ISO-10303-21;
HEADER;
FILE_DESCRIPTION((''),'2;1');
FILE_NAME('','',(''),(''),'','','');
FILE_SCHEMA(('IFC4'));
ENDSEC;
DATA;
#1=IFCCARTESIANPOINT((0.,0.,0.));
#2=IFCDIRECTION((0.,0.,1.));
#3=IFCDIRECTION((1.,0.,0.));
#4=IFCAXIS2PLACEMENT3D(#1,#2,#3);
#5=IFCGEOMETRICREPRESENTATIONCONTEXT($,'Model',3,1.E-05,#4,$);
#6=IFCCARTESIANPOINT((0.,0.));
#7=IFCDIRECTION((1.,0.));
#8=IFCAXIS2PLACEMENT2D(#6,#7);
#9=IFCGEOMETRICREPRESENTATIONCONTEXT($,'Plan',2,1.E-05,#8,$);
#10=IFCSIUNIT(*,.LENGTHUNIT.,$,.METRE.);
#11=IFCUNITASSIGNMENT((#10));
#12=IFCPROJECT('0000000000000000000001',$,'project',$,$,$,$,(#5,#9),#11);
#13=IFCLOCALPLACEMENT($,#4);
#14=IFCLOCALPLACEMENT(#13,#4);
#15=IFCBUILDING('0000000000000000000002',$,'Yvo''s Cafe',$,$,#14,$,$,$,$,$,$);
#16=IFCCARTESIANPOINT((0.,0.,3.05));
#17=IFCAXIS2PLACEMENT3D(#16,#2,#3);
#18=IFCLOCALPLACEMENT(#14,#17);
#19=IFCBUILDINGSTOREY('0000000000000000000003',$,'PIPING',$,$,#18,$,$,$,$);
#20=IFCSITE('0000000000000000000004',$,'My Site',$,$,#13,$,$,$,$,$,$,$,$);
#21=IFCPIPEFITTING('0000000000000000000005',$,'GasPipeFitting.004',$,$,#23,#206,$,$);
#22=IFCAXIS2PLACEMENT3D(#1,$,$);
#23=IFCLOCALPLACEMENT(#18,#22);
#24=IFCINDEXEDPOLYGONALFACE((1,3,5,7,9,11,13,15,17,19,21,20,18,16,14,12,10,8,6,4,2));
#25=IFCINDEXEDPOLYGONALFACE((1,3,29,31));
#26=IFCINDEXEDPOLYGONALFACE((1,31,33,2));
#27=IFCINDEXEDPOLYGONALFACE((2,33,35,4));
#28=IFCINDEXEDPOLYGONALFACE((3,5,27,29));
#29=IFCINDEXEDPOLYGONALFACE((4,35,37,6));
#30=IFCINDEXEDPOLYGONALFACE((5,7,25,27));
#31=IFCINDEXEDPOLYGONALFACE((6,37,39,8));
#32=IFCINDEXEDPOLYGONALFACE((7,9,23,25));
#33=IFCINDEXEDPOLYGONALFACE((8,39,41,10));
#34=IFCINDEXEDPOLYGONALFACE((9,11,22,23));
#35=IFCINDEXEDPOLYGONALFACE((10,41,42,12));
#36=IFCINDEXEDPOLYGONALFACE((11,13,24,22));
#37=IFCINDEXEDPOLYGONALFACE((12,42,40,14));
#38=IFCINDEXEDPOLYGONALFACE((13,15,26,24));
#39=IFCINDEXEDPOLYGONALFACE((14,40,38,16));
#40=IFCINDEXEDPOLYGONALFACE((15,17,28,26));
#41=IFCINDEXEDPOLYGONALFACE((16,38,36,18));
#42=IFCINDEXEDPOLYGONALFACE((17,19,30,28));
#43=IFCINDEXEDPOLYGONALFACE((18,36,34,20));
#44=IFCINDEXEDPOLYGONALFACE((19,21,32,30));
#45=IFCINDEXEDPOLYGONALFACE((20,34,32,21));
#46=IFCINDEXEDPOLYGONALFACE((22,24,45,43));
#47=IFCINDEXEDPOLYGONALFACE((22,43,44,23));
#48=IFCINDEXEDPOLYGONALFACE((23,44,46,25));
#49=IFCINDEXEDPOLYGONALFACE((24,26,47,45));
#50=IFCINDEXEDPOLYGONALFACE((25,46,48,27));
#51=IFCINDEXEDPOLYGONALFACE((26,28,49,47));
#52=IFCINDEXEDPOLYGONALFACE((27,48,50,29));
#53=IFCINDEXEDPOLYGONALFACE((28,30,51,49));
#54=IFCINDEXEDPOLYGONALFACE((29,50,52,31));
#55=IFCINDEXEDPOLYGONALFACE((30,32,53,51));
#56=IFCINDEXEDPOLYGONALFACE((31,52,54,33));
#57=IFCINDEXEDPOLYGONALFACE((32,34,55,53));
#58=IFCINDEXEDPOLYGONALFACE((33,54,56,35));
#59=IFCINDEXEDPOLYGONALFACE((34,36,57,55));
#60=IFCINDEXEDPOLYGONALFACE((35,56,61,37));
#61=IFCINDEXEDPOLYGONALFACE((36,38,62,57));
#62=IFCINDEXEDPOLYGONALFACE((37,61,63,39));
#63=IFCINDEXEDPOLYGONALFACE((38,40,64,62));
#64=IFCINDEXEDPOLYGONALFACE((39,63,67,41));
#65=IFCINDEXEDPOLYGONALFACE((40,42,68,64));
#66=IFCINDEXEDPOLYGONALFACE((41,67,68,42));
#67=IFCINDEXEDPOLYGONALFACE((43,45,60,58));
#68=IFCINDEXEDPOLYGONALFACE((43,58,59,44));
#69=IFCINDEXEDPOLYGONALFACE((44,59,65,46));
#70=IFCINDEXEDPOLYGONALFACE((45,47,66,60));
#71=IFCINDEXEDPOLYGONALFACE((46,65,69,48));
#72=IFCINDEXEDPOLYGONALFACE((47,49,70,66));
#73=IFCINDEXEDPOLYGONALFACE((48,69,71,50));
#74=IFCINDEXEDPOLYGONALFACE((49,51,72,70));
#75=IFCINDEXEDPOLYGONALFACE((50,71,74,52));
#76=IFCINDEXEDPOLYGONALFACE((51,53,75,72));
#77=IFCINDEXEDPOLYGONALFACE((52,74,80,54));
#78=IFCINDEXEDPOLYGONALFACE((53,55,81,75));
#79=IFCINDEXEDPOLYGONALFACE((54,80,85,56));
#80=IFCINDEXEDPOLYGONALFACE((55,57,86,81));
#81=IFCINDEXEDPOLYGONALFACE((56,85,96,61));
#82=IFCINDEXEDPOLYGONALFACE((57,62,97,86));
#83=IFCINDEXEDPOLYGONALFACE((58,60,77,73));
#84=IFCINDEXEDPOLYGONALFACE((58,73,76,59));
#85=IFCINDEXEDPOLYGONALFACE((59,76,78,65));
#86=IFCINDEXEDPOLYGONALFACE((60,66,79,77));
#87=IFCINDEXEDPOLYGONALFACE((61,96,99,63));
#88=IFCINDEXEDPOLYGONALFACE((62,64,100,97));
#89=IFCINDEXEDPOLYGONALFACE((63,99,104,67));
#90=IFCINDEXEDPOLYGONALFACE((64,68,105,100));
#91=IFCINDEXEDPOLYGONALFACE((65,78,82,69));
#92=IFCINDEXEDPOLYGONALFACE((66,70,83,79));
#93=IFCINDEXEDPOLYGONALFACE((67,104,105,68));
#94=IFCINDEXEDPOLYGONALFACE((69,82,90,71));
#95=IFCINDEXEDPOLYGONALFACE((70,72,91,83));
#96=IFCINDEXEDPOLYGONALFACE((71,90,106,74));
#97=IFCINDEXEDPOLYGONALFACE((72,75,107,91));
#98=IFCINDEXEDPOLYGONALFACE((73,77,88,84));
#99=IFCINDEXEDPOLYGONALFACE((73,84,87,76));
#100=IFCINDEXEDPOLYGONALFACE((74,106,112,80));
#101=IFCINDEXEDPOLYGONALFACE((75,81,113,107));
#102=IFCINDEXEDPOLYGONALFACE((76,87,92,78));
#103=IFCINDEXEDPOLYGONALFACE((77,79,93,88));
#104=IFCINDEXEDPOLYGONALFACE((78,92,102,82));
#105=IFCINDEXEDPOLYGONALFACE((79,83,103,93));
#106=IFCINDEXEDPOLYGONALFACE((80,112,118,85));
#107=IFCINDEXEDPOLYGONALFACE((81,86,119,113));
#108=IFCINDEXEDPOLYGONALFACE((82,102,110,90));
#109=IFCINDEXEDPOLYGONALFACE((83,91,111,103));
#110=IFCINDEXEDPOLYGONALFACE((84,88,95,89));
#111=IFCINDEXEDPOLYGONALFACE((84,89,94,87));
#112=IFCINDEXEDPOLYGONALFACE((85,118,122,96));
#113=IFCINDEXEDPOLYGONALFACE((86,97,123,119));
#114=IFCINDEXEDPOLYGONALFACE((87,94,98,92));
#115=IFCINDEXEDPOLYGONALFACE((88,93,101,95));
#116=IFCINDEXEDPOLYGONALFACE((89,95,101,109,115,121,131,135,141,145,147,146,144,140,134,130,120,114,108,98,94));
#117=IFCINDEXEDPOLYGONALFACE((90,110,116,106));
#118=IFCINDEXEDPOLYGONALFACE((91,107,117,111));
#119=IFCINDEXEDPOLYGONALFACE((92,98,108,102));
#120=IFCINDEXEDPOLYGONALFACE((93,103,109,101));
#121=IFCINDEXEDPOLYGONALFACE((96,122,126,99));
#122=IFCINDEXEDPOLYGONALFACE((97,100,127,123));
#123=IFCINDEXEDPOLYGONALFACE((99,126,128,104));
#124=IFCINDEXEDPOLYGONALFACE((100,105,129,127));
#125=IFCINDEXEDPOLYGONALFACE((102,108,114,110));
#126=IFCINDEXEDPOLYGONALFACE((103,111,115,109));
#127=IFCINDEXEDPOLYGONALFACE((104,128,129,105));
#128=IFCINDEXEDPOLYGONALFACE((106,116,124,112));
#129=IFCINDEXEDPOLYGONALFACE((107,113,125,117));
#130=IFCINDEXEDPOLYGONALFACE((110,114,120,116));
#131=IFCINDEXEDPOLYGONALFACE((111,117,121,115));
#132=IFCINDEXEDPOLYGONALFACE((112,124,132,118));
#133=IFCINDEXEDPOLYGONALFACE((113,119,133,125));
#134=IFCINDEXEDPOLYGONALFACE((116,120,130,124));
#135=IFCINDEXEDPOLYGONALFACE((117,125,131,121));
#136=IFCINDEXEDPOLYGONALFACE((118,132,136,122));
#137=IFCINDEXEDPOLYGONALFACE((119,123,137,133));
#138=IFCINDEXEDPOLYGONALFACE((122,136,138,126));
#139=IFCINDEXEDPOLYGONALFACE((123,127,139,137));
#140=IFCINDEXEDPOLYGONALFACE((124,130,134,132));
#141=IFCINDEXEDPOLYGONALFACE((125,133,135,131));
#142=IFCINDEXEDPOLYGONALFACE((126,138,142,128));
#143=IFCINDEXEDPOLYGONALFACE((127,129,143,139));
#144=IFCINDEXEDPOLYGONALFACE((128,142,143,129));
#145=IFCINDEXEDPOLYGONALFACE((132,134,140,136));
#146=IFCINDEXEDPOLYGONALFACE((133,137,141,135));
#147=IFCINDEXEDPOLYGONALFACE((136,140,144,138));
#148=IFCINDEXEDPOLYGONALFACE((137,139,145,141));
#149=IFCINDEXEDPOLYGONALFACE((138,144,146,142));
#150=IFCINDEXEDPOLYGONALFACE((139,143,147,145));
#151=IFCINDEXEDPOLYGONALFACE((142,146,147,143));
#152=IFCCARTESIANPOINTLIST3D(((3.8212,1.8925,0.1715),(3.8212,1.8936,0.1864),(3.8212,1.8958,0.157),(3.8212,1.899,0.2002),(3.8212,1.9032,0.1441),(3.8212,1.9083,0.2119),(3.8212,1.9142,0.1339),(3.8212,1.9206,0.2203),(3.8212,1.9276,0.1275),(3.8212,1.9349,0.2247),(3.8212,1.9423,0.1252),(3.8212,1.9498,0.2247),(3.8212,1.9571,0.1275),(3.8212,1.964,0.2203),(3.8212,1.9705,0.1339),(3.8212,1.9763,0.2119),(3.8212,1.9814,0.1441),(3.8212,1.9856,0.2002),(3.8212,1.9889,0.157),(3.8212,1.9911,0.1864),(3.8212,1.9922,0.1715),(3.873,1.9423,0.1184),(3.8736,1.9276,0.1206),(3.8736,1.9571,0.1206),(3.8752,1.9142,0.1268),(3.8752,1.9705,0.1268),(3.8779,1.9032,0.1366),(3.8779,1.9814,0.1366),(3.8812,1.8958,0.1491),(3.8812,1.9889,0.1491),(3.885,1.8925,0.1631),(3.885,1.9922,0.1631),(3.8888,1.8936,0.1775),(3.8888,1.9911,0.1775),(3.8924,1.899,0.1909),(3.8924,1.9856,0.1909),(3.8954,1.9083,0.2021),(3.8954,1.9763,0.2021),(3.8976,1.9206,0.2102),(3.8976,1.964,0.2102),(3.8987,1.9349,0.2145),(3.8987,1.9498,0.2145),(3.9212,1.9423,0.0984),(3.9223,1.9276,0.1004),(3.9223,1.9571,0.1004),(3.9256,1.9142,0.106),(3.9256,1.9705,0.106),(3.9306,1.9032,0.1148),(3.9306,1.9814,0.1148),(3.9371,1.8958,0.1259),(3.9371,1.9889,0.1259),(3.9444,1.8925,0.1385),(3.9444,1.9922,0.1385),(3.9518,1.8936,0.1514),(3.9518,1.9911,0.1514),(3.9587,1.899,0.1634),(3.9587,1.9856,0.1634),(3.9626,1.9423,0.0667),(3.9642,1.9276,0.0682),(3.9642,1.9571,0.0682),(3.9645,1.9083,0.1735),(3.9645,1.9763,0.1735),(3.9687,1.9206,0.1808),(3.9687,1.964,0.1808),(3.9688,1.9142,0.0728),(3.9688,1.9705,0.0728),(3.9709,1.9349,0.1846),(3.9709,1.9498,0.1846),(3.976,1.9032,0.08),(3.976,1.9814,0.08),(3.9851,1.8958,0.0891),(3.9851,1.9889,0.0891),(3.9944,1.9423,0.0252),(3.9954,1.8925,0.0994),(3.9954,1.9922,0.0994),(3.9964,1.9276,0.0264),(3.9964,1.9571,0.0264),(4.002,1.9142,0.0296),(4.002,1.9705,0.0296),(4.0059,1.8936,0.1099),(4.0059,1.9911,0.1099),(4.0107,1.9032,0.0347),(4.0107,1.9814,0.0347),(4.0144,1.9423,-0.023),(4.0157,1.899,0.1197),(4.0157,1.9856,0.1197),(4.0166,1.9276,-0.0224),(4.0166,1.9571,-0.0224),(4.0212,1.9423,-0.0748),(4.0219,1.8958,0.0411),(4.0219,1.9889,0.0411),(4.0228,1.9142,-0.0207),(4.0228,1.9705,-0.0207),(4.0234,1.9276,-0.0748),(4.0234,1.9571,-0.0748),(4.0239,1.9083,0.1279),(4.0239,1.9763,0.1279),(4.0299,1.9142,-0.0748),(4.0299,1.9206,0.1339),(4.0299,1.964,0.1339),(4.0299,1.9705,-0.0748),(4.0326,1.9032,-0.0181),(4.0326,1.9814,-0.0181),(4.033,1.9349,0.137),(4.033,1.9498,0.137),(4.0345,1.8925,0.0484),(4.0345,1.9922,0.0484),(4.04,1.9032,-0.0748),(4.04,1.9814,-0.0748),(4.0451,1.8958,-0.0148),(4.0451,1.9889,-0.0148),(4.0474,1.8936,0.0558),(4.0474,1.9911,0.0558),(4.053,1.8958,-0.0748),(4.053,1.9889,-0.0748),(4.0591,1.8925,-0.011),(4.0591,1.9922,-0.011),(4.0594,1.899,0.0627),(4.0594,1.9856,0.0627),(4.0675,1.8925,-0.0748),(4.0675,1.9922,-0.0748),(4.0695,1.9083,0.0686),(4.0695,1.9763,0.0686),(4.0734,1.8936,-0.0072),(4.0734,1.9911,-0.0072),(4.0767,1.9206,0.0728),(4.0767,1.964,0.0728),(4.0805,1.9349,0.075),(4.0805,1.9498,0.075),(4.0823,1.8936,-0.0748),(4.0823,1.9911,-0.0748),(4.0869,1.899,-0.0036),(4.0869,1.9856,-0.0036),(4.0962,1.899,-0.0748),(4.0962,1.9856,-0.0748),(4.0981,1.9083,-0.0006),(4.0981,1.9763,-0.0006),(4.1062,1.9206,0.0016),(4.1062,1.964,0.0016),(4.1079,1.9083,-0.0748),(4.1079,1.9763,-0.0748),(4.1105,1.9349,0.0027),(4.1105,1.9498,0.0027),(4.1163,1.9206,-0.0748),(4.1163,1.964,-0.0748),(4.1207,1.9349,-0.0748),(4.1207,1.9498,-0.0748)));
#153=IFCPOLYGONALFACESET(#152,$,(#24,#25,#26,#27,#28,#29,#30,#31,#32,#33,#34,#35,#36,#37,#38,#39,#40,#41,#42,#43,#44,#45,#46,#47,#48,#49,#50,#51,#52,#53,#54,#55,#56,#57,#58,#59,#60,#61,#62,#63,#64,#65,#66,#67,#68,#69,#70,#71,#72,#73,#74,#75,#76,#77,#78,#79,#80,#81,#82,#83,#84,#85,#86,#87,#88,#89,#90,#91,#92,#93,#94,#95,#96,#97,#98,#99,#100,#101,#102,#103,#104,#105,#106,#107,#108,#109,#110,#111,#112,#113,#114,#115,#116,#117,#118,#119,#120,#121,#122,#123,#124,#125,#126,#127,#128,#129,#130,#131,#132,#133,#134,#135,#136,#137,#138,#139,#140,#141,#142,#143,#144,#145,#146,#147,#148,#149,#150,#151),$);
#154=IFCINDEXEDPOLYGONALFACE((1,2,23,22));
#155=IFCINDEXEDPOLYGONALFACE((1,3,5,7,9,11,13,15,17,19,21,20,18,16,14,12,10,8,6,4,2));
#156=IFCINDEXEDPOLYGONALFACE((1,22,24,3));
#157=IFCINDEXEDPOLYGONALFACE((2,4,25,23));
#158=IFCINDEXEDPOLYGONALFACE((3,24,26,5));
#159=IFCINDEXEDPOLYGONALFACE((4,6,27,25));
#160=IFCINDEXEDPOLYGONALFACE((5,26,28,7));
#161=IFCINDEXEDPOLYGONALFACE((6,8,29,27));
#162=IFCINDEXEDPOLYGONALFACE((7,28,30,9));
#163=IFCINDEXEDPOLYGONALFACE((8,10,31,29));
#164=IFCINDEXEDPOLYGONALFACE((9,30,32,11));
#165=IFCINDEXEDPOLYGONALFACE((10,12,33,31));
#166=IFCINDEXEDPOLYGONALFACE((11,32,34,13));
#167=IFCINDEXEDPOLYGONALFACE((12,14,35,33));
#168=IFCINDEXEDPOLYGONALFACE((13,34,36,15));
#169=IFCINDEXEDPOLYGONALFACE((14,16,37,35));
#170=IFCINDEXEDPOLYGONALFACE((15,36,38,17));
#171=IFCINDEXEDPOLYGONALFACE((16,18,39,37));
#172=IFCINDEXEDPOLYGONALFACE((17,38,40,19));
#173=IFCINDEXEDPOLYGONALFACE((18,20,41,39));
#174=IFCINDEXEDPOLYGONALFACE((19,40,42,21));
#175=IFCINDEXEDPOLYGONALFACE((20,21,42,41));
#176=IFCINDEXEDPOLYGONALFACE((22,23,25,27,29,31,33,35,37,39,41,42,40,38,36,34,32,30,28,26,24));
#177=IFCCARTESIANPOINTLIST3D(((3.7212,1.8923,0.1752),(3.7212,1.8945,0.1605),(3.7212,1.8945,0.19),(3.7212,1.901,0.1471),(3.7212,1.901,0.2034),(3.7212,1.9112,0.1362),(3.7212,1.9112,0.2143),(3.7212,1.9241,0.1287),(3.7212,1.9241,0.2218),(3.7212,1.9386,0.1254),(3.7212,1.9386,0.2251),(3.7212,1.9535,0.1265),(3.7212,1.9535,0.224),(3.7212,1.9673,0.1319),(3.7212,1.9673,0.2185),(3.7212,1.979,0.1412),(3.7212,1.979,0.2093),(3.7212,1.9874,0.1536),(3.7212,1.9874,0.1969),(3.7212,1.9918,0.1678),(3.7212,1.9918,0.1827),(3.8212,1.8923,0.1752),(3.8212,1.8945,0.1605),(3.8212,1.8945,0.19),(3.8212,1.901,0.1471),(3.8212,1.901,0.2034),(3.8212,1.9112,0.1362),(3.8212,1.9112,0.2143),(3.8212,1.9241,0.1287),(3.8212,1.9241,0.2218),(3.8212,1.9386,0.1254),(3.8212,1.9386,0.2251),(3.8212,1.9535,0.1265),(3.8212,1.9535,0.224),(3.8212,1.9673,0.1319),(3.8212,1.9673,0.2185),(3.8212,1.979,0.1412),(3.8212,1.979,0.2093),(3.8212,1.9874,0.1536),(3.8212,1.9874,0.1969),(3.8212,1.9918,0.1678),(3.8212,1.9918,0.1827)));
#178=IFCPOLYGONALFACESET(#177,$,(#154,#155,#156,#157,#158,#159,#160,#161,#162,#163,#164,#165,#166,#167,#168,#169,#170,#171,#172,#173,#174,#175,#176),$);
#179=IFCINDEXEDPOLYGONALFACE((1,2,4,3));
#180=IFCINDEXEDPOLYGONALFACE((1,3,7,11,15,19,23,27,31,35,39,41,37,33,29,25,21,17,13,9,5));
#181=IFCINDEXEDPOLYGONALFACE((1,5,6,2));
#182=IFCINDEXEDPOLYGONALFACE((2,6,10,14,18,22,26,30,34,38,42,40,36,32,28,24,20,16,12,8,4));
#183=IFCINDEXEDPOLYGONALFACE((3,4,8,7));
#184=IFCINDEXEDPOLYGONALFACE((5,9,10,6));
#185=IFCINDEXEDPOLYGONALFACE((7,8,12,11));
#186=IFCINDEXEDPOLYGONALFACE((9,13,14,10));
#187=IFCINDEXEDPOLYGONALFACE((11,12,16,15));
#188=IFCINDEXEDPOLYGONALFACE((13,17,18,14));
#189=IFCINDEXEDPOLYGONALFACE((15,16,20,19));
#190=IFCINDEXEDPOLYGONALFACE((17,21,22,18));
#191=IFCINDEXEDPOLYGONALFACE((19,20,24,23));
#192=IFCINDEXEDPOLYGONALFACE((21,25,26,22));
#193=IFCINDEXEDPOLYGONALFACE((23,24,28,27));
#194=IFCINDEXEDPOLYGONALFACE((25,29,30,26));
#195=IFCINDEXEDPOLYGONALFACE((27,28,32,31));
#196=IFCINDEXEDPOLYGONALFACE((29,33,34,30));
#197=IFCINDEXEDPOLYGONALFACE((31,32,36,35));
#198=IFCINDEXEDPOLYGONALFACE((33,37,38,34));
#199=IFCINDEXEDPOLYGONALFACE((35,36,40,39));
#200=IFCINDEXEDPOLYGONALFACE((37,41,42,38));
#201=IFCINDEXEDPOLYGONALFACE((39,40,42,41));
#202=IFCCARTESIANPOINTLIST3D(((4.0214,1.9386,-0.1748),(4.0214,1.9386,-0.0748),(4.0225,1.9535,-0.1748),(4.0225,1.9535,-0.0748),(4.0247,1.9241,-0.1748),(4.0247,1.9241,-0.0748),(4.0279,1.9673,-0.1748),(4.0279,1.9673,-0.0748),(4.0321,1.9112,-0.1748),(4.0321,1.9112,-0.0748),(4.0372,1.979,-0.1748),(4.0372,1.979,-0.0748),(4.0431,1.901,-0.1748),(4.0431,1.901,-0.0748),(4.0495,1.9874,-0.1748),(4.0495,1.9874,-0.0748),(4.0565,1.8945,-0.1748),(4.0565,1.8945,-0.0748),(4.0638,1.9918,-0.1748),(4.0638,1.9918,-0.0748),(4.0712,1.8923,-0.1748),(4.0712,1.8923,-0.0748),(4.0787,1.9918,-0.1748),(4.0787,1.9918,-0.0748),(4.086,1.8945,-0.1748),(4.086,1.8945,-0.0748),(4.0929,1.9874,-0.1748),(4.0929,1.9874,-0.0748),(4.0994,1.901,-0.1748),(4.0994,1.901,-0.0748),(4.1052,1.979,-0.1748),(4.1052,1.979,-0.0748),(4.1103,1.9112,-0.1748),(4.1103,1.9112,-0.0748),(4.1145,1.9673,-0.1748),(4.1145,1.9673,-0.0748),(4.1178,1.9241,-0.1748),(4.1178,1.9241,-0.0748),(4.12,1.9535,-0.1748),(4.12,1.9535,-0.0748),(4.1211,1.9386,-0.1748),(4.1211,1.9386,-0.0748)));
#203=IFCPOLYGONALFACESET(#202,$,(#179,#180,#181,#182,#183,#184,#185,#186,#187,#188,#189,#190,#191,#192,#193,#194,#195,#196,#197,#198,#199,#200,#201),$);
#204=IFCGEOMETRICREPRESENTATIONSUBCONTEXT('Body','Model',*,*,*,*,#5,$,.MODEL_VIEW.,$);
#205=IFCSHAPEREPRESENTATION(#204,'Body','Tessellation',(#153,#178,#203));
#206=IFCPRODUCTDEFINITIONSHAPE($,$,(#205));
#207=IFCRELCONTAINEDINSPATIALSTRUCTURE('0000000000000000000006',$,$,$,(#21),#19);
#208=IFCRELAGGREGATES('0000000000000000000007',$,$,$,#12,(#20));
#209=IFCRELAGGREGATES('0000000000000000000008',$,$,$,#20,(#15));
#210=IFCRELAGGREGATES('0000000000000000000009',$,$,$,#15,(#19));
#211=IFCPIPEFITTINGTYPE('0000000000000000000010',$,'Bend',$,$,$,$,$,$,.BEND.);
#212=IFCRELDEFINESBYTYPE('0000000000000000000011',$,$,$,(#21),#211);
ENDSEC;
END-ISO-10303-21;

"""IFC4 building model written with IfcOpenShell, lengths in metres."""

from ifc_helpers import new_model, entity, si_unit, frame, origin_with_axes, origin_2d_with_axis, place, context, subcontext, project, spatial, circle, extrude, source, transform, mapped, type_object, type_shapes, element, save


model = new_model("IFC4")

# Units and contexts
model_context = context("Model", 3, precision=1e-05, world=origin_with_axes())
plan_context = context("Plan", 2, precision=1e-05, world=origin_2d_with_axis())
body_context = subcontext(model_context, "Body", "Model", "MODEL_VIEW")
ifc_project = project(units=[si_unit("LENGTHUNIT", "METRE")], contexts=[model_context, plan_context])

# Site, building, storey
site_placement = place(None, origin_with_axes())
site = spatial("IfcSite", under=ifc_project, at=site_placement, Name="My Site")
building_placement = place(site_placement, origin_with_axes())
building = spatial("IfcBuilding", under=site, at=building_placement, Name="Yvo's Cafe")
storey_placement = place(building_placement, frame((0.0, 0.0, 3.05), z_axis=(0.0, 0.0, 1.0), x_axis=(1.0, 0.0, 0.0)))
storey = spatial("IfcBuildingStorey", under=building, at=storey_placement, Name="PIPING")

# Shared definitions
pipe_fitting_type_1 = type_object("IfcPipeFittingType", Name="Bend", PredefinedType="BEND")
shared_shape_1 = source(origin_with_axes(), body_context, "Body", "SolidModel", [
    entity("IfcSweptDiskSolid", entity("IfcIndexedPolyCurve", entity("IfcCartesianPointList3D", [[0.0, 0.0, -0.1], [0.0, -0.0732, -0.2768], [0.0, -0.25, -0.35]]), [entity("IfcArcIndex", [1, 2, 3])]), 0.05),
    extrude(circle(Radius=0.05), origin_with_axes(), (0.0, 0.0, -1.0), 0.1),
    extrude(circle(Radius=0.05), frame((0.0, -0.25, -0.35), z_axis=(0.0, -1.0, 0.0), x_axis=(1.0, 0.0, 0.0)), (0.0, 0.0, 1.0), 0.1),
])
type_shapes(pipe_fitting_type_1, [shared_shape_1])

# Pipe fitting
for number, where, z_axis, x_axis, name in (
    (1, (3.7212, 1.9423, 0.1752), (-1.0, 0.0, 0.0), (0.0, -1.0, 0.0), "GasPipeFitting.004"),
):
    element("IfcPipeFitting", number, at=place(storey_placement, frame(where, z_axis=z_axis, x_axis=x_axis)), inside=storey, type_object=pipe_fitting_type_1, Name=name, context=body_context, shape_type="MappedRepresentation", body=[
        mapped(shared_shape_1, transform((0.0, 0.0, 0.0), x_axis=(1.0, 0.0, 0.0), y_axis=(0.0, 1.0, 0.0), z_axis=(0.0, 0.0, 1.0), scale=1.0)),
    ])

save(model, "model.ifc")
